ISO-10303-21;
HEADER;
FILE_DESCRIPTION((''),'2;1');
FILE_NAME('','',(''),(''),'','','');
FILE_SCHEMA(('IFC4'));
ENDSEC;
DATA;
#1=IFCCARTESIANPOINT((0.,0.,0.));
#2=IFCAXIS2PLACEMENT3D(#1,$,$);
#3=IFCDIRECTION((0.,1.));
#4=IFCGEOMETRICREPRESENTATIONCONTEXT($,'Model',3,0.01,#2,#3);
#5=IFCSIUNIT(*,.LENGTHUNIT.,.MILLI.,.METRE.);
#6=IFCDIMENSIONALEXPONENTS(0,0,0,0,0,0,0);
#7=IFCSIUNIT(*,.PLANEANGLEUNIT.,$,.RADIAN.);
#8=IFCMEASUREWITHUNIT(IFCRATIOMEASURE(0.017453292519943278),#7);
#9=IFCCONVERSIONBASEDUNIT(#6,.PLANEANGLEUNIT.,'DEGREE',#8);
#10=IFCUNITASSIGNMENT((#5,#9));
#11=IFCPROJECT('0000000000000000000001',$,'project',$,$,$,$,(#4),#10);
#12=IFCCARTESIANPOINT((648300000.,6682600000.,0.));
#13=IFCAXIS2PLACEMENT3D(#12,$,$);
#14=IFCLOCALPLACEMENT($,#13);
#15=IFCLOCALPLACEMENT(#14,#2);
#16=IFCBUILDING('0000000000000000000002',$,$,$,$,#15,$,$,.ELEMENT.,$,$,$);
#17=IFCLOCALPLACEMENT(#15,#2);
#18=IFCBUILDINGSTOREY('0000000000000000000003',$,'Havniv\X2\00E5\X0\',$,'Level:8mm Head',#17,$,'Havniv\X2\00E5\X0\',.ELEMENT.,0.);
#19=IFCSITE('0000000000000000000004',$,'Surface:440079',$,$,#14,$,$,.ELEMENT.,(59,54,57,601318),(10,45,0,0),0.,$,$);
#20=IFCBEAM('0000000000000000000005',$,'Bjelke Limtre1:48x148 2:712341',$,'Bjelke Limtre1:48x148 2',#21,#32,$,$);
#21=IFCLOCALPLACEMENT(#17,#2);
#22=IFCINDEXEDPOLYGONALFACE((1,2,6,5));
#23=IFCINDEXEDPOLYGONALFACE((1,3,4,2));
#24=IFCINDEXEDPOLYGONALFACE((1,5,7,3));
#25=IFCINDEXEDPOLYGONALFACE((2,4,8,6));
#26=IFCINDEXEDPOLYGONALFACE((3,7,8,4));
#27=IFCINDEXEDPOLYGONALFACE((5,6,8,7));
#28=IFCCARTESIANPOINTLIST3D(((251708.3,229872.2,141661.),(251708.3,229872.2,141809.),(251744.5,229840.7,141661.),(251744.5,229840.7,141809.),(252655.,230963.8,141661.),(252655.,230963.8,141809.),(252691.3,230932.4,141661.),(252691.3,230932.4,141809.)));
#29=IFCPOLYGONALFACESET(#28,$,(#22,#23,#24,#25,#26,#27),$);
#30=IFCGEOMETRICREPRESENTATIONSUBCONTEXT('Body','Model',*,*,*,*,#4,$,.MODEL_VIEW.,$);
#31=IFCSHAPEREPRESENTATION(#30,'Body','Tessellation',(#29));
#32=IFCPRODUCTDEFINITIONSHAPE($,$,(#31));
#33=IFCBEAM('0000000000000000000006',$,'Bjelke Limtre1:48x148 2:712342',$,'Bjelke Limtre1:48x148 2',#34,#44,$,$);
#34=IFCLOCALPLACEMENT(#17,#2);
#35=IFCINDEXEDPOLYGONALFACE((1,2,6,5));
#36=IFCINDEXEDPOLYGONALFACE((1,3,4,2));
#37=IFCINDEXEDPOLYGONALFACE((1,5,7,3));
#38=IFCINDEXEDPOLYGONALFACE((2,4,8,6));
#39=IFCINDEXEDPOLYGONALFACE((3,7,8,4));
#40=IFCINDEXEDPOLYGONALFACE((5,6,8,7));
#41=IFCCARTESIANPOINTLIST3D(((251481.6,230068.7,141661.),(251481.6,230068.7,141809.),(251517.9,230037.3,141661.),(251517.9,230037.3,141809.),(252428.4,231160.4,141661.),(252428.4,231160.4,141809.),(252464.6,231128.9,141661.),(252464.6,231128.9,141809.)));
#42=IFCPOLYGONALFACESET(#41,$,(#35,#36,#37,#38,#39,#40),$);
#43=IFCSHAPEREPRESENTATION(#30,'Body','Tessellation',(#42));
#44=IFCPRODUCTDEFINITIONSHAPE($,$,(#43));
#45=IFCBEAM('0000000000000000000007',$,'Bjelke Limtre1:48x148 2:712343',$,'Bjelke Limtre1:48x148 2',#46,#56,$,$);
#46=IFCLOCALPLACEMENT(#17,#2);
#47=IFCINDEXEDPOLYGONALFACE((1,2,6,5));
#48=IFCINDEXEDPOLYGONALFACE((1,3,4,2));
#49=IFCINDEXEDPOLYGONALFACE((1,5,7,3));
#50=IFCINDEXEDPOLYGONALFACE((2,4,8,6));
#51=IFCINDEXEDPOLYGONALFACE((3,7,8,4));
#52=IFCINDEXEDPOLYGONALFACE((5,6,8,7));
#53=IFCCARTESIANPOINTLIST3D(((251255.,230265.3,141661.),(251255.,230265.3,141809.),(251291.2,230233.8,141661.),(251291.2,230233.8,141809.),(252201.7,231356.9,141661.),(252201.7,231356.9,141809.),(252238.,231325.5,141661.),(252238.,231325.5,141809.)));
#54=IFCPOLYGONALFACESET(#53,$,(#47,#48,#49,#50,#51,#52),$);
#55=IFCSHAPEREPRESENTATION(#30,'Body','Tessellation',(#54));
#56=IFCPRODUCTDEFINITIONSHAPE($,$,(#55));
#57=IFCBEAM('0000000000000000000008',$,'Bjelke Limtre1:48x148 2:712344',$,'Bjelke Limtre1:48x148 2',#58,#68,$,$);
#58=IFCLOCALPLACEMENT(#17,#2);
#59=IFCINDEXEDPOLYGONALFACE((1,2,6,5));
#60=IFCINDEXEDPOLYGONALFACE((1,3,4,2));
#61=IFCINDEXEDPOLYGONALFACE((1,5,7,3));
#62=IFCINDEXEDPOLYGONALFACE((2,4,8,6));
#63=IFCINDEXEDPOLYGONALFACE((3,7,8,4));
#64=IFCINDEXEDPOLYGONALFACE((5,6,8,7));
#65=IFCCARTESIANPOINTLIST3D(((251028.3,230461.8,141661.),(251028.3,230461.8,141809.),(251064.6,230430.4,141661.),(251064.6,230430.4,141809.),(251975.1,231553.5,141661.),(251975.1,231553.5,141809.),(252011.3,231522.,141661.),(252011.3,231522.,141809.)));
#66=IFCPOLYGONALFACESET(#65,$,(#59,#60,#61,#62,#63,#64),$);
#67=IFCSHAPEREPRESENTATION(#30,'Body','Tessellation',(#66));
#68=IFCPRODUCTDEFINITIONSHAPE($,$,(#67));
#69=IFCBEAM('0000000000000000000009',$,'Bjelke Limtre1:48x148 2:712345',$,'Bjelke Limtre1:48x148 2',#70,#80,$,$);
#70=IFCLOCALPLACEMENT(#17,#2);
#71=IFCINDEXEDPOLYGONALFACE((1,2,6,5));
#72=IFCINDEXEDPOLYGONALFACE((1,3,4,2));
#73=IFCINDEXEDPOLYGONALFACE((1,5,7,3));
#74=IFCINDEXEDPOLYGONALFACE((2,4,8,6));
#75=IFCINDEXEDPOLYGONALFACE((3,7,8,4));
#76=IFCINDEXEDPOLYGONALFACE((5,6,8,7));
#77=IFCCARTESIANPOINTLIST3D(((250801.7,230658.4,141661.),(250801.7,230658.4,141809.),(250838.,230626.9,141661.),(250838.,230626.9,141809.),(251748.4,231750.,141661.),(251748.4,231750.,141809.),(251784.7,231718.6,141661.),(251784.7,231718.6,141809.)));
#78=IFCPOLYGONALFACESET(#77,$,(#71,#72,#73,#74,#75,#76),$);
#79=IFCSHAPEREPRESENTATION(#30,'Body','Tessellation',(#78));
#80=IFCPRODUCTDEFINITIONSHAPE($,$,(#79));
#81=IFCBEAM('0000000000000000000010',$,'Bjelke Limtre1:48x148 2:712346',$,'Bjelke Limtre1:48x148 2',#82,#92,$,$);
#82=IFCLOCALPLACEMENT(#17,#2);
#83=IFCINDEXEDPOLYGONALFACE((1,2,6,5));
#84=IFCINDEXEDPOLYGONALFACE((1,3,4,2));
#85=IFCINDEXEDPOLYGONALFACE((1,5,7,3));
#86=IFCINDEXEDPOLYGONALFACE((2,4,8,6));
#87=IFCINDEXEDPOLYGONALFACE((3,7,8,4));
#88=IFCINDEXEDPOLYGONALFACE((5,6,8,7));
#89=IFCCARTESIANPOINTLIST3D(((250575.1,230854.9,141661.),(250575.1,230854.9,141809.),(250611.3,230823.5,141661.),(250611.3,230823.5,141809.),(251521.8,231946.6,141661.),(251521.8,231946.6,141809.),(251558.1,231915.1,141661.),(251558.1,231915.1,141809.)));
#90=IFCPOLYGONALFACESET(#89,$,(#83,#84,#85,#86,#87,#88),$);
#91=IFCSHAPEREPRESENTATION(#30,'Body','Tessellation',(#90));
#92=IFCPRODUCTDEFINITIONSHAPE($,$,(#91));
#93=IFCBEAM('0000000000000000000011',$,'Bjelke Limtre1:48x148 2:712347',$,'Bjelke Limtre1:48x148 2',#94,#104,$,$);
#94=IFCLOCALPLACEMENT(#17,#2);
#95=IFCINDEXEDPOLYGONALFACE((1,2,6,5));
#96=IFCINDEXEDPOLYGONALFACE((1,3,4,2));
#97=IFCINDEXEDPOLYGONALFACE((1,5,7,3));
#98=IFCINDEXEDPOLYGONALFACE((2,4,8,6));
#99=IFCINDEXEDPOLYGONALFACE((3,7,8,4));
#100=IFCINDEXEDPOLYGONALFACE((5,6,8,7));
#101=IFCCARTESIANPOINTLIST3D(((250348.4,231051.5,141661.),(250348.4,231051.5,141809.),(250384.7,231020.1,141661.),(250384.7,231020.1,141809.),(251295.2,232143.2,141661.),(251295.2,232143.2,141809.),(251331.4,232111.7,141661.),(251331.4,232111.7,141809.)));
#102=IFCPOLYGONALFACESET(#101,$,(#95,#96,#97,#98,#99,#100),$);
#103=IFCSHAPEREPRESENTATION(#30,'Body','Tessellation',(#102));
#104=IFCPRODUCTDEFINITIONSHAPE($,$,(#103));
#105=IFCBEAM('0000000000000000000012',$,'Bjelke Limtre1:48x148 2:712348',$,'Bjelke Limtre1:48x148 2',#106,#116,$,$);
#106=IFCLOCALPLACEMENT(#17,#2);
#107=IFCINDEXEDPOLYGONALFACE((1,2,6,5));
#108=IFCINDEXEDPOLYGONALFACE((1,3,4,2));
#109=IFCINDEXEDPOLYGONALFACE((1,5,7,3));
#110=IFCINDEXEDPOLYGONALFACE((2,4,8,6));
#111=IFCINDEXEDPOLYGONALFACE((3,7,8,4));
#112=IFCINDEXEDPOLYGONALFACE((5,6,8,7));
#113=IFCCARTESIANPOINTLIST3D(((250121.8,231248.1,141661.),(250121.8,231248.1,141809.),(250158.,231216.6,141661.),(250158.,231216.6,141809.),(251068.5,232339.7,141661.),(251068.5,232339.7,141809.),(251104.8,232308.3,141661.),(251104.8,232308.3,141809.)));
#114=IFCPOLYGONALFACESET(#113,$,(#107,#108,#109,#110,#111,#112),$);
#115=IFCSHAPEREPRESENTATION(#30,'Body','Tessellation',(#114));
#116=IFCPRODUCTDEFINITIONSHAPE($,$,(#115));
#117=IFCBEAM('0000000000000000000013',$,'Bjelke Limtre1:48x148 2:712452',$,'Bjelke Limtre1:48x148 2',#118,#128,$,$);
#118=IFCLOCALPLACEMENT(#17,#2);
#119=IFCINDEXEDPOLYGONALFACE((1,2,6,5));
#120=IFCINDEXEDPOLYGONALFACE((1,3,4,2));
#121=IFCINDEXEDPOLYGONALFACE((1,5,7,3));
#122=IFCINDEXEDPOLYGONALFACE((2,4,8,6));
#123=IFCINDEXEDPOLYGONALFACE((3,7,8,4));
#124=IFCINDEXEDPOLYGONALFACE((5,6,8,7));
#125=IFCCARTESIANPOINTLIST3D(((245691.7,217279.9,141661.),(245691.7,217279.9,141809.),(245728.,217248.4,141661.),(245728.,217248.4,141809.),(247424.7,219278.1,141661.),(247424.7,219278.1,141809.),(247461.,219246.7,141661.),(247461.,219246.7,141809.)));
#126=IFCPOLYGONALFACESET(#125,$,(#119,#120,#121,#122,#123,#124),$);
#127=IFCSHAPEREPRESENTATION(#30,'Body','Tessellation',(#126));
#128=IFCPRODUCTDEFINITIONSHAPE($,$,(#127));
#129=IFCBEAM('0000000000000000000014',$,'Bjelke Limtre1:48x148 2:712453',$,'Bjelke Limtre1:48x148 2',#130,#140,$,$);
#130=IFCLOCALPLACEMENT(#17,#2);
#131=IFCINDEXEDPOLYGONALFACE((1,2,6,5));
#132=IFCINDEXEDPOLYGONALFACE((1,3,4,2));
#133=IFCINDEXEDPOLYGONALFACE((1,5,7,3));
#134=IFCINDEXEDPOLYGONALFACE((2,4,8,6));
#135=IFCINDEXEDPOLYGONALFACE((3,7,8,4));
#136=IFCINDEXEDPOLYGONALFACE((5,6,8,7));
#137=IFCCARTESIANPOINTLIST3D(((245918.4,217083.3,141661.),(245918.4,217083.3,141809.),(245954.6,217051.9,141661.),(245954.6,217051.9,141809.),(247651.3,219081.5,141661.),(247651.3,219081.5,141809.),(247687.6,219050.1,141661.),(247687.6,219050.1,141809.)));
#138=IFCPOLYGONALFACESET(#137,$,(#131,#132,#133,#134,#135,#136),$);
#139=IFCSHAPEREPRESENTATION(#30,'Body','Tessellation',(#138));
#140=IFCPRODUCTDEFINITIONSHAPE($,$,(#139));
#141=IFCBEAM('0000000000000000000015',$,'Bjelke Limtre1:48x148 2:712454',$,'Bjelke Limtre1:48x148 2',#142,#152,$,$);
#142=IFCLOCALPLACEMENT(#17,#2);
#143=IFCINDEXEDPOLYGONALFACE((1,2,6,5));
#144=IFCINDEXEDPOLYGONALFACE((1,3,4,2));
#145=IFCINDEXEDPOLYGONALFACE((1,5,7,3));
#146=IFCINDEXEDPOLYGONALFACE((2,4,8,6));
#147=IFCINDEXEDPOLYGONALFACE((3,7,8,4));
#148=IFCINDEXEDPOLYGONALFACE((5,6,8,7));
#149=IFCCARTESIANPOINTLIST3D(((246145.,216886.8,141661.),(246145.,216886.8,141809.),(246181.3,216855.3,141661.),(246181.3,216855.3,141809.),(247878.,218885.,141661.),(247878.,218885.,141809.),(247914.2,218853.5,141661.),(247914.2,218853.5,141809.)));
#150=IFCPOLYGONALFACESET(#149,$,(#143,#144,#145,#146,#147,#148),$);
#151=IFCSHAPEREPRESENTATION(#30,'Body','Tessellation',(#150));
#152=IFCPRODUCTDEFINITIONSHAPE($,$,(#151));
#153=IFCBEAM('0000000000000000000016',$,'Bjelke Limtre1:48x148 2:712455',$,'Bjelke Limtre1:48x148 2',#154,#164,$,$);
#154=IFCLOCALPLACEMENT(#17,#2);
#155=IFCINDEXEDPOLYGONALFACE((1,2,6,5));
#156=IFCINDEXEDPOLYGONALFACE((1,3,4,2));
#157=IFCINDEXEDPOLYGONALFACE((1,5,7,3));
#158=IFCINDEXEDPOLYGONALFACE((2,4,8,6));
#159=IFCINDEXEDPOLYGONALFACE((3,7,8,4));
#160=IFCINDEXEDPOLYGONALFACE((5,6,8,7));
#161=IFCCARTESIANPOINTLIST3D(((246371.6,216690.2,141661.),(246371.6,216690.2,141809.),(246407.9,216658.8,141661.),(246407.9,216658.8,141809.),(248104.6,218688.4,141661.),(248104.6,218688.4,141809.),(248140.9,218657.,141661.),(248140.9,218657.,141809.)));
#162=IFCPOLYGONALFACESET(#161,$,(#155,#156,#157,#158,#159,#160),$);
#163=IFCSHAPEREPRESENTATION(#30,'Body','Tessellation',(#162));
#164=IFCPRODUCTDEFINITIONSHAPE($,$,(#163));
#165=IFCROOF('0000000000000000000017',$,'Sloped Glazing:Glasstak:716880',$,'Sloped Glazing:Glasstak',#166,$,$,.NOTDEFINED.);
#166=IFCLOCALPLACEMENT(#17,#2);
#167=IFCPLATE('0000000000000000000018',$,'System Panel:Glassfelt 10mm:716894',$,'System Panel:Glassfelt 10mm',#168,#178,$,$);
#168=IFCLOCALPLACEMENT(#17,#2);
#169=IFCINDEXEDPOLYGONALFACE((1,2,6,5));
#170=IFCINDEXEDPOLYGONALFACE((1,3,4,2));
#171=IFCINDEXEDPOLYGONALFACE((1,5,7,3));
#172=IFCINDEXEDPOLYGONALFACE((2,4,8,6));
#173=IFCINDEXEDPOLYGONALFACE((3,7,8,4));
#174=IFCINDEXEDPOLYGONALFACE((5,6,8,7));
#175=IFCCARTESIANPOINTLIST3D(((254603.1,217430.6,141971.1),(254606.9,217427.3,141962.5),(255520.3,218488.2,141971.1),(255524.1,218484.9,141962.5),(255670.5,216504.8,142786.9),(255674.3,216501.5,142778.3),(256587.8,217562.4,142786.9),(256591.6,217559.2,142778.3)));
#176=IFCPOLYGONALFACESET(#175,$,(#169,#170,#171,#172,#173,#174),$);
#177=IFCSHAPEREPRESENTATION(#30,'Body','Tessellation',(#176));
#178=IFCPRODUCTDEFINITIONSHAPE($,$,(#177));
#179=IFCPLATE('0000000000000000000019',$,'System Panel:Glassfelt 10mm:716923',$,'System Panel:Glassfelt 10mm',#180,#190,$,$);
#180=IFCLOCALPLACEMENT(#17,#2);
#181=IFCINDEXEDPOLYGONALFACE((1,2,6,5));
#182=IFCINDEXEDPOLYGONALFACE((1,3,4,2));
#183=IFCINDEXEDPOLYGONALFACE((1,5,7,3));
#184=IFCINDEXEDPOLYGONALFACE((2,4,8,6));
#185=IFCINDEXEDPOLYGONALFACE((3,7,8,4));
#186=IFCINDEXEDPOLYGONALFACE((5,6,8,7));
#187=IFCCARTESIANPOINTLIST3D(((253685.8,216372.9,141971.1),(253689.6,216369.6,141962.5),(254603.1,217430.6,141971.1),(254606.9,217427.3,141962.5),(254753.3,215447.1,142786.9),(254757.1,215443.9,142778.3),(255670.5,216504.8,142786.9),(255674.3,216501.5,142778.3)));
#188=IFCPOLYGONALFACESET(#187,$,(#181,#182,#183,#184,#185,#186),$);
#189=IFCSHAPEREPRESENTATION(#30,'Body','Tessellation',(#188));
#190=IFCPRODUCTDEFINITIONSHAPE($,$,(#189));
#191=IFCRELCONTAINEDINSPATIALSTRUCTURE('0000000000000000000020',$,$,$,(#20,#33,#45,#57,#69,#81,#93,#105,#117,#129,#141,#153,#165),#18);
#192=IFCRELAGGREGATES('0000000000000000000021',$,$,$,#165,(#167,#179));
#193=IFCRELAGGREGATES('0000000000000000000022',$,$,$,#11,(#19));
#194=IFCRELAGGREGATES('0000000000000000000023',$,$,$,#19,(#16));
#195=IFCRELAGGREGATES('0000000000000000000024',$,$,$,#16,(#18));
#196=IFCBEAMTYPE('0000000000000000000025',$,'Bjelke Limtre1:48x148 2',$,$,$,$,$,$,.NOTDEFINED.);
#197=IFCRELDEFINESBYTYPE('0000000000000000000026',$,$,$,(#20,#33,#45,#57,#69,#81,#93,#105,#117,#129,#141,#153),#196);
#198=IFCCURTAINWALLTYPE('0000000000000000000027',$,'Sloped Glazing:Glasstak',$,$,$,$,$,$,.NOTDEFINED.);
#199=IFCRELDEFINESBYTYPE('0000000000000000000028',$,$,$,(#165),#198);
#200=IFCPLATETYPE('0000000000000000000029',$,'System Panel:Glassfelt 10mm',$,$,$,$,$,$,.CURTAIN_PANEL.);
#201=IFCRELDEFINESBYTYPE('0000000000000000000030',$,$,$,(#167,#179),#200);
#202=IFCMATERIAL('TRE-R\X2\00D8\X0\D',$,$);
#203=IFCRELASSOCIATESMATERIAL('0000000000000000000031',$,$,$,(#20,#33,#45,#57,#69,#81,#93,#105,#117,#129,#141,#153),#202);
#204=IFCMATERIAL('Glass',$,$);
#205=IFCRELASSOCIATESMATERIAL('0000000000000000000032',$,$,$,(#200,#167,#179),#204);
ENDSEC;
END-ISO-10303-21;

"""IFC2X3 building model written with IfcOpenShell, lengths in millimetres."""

from ifc_helpers import new_model, entity, si_unit, converted_unit, direction, frame, frame_2d, origin, origin_2d_with_axis, place, context, subcontext, project, spatial, rectangle, extrude, source, transform, mapped, material, type_object, type_shapes, element, aggregate, save


model = new_model("IFC2X3")

# Units and contexts
model_context = context("Model", 3, precision=0.01, world=origin(), true_north=direction((0.0, 1.0)))
body_context = subcontext(model_context, "Body", "Model", "MODEL_VIEW")
ifc_project = project(units=[si_unit("LENGTHUNIT", "METRE", prefix="MILLI"), converted_unit("PLANEANGLEUNIT", "DEGREE", entity("IfcRatioMeasure", 0.017453292519943278), si_unit("PLANEANGLEUNIT", "RADIAN"), dimensions=[0, 0, 0, 0, 0, 0, 0])], contexts=[model_context])

# Site, building, storey
site_placement = place(None, frame((648300000.0, 6682600000.0, 0.0)))
site = spatial("IfcSite", under=ifc_project, at=site_placement, Name="Surface:440079", CompositionType="ELEMENT", RefLatitude=(59, 54, 57, 601318), RefLongitude=(10, 45, 0, 0), RefElevation=0.0)
building_placement = place(site_placement, origin())
building = spatial("IfcBuilding", under=site, at=building_placement, CompositionType="ELEMENT")
storey_placement = place(building_placement, origin())
storey = spatial("IfcBuildingStorey", under=building, at=storey_placement, Name="Havnivå", ObjectType="Level:8mm Head", LongName="Havnivå", CompositionType="ELEMENT", Elevation=0.0)

# Beams
ifc_material_1 = material(Name="TRE-RØD")
beam_type = type_object("IfcBeamType", Name="Bjelke Limtre1:48x148 2", PredefinedType="NOTDEFINED")
beam_1_placement = place(storey_placement, frame((252673.1, 230948.1, 141809.0), z_axis=(0.0, 0.0, 1.0), x_axis=(-0.655187, -0.755467, 0.0)))
element("IfcBeam", 1, at=beam_1_placement, inside=storey, type_object=beam_type, material=ifc_material_1, Name="Bjelke Limtre1:48x148 2:712341", ObjectType="Bjelke Limtre1:48x148 2", context=body_context, shape_type="SweptSolid", body=[
    extrude(rectangle(XDim=148.0, YDim=48.0, at=frame_2d((0.0, 0.0), x_axis=(1.0, 0.0))), frame((0.0, 0.0, -74.0), z_axis=(1.0, 0.0, 0.0), x_axis=(0.0, 0.0, -1.0)), (0.0, 0.0, 1.0), 1445.0),
])
beam_2_placement = place(storey_placement, frame((252446.5, 231144.6, 141809.0), z_axis=(0.0, 0.0, 1.0), x_axis=(-0.655187, -0.755467, 0.0)))
element("IfcBeam", 2, at=beam_2_placement, inside=storey, type_object=beam_type, material=ifc_material_1, Name="Bjelke Limtre1:48x148 2:712342", ObjectType="Bjelke Limtre1:48x148 2", context=body_context, shape_type="SweptSolid", body=[
    extrude(rectangle(XDim=148.0, YDim=48.0, at=frame_2d((0.0, 0.0), x_axis=(1.0, 0.0))), frame((0.0, 0.0, -74.0), z_axis=(1.0, 0.0, 0.0), x_axis=(0.0, 0.0, -1.0)), (0.0, 0.0, 1.0), 1445.0),
])
beam_3_placement = place(storey_placement, frame((252219.9, 231341.2, 141809.0), z_axis=(0.0, 0.0, 1.0), x_axis=(-0.655187, -0.755467, 0.0)))
element("IfcBeam", 3, at=beam_3_placement, inside=storey, type_object=beam_type, material=ifc_material_1, Name="Bjelke Limtre1:48x148 2:712343", ObjectType="Bjelke Limtre1:48x148 2", context=body_context, shape_type="SweptSolid", body=[
    extrude(rectangle(XDim=148.0, YDim=48.0, at=origin_2d_with_axis()), frame((0.0, 0.0, -74.0), z_axis=(1.0, 0.0, 0.0), x_axis=(0.0, 0.0, -1.0)), (0.0, 0.0, 1.0), 1445.0),
])
beam_4_placement = place(storey_placement, frame((251993.2, 231537.8, 141809.0), z_axis=(0.0, 0.0, 1.0), x_axis=(-0.655187, -0.755467, 0.0)))
element("IfcBeam", 4, at=beam_4_placement, inside=storey, type_object=beam_type, material=ifc_material_1, Name="Bjelke Limtre1:48x148 2:712344", ObjectType="Bjelke Limtre1:48x148 2", context=body_context, shape_type="SweptSolid", body=[
    extrude(rectangle(XDim=148.0, YDim=48.0, at=frame_2d((0.0, 0.0), x_axis=(1.0, 0.0))), frame((0.0, 0.0, -74.0), z_axis=(1.0, 0.0, 0.0), x_axis=(0.0, 0.0, -1.0)), (0.0, 0.0, 1.0), 1445.0),
])
for number, where, z_axis, x_axis, name in (
    (5, (251766.6, 231734.3, 141809.0), (0.0, 0.0, 1.0), (-0.655187, -0.755467, 0.0), "Bjelke Limtre1:48x148 2:712345"),
    (6, (251539.9, 231930.9, 141809.0), (0.0, 0.0, 1.0), (-0.655187, -0.755467, 0.0), "Bjelke Limtre1:48x148 2:712346"),
):
    element("IfcBeam", number, at=place(storey_placement, frame(where, z_axis=z_axis, x_axis=x_axis)), inside=storey, type_object=beam_type, material=ifc_material_1, Name=name, ObjectType="Bjelke Limtre1:48x148 2", context=body_context, shape_type="SweptSolid", body=[
        extrude(rectangle(XDim=148.0, YDim=48.0, at=origin_2d_with_axis()), frame((0.0, 0.0, -74.0), z_axis=(1.0, 0.0, 0.0), x_axis=(0.0, 0.0, -1.0)), (0.0, 0.0, 1.0), 1445.0),
    ])
for number, where, z_axis, x_axis, name in (
    (7, (251313.3, 232127.4, 141809.0), (0.0, 0.0, 1.0), (-0.655187, -0.755467, 0.0), "Bjelke Limtre1:48x148 2:712347"),
    (8, (251086.7, 232324.0, 141809.0), (0.0, 0.0, 1.0), (-0.655187, -0.755467, 0.0), "Bjelke Limtre1:48x148 2:712348"),
):
    element("IfcBeam", number, at=place(storey_placement, frame(where, z_axis=z_axis, x_axis=x_axis)), inside=storey, type_object=beam_type, material=ifc_material_1, Name=name, ObjectType="Bjelke Limtre1:48x148 2", context=body_context, shape_type="SweptSolid", body=[
        extrude(rectangle(XDim=148.0, YDim=48.0, at=frame_2d((0.0, 0.0), x_axis=(1.0, 0.0))), frame((0.0, 0.0, -74.0), z_axis=(1.0, 0.0, 0.0), x_axis=(0.0, 0.0, -1.0)), (0.0, 0.0, 1.0), 1445.0),
    ])
beam_5_placement = place(storey_placement, frame((247442.8, 219262.4, 141809.0), z_axis=(0.0, 0.0, 1.0), x_axis=(-0.655187, -0.755467, 0.0)))
element("IfcBeam", 9, at=beam_5_placement, inside=storey, type_object=beam_type, material=ifc_material_1, Name="Bjelke Limtre1:48x148 2:712452", ObjectType="Bjelke Limtre1:48x148 2", context=body_context, shape_type="SweptSolid", body=[
    extrude(rectangle(XDim=148.0, YDim=48.0, at=frame_2d((0.0, 0.0), x_axis=(1.0, 0.0))), frame((0.0, 0.0, -74.0), z_axis=(1.0, 0.0, 0.0), x_axis=(0.0, 0.0, -1.0)), (0.0, 0.0, 1.0), 2645.0),
])
beam_6_placement = place(storey_placement, frame((247669.5, 219065.8, 141809.0), z_axis=(0.0, 0.0, 1.0), x_axis=(-0.655187, -0.755467, 0.0)))
element("IfcBeam", 10, at=beam_6_placement, inside=storey, type_object=beam_type, material=ifc_material_1, Name="Bjelke Limtre1:48x148 2:712453", ObjectType="Bjelke Limtre1:48x148 2", context=body_context, shape_type="SweptSolid", body=[
    extrude(rectangle(XDim=148.0, YDim=48.0, at=origin_2d_with_axis()), frame((0.0, 0.0, -74.0), z_axis=(1.0, 0.0, 0.0), x_axis=(0.0, 0.0, -1.0)), (0.0, 0.0, 1.0), 2645.0),
])
beam_7_placement = place(storey_placement, frame((247896.1, 218869.3, 141809.0), z_axis=(0.0, 0.0, 1.0), x_axis=(-0.655187, -0.755467, 0.0)))
element("IfcBeam", 11, at=beam_7_placement, inside=storey, type_object=beam_type, material=ifc_material_1, Name="Bjelke Limtre1:48x148 2:712454", ObjectType="Bjelke Limtre1:48x148 2", context=body_context, shape_type="SweptSolid", body=[
    extrude(rectangle(XDim=148.0, YDim=48.0, at=frame_2d((0.0, 0.0), x_axis=(1.0, 0.0))), frame((0.0, 0.0, -74.0), z_axis=(1.0, 0.0, 0.0), x_axis=(0.0, 0.0, -1.0)), (0.0, 0.0, 1.0), 2645.0),
])
beam_8_placement = place(storey_placement, frame((248122.7, 218672.7, 141809.0), z_axis=(0.0, 0.0, 1.0), x_axis=(-0.655187, -0.755467, 0.0)))
element("IfcBeam", 12, at=beam_8_placement, inside=storey, type_object=beam_type, material=ifc_material_1, Name="Bjelke Limtre1:48x148 2:712455", ObjectType="Bjelke Limtre1:48x148 2", context=body_context, shape_type="SweptSolid", body=[
    extrude(rectangle(XDim=148.0, YDim=48.0, at=origin_2d_with_axis()), frame((0.0, 0.0, -74.0), z_axis=(1.0, 0.0, 0.0), x_axis=(0.0, 0.0, -1.0)), (0.0, 0.0, 1.0), 2645.0),
])

# Roof, plates
curtain_wall_type = type_object("IfcCurtainWallType", Name="Sloped Glazing:Glasstak", PredefinedType="NOTDEFINED")
roof_placement = place(storey_placement, origin())
roof = element("IfcRoof", 13, at=roof_placement, inside=storey, type_object=curtain_wall_type, Name="Sloped Glazing:Glasstak:716880", ObjectType="Sloped Glazing:Glasstak", ShapeType="NOTDEFINED")
ifc_material_2 = material(Name="Glass")
plate_type = type_object("IfcPlateType", Name="System Panel:Glassfelt 10mm", PredefinedType="CURTAIN_PANEL", material=ifc_material_2)
shared_shape_1 = source(origin(), body_context, "Body", "SweptSolid", [
    extrude(rectangle(XDim=10.0, YDim=1400.0, at=frame_2d((0.0, 0.0), x_axis=(1.0, 0.0))), frame((0.0, 10.0, 0.0), z_axis=(0.0, 0.0, 1.0), x_axis=(0.0, 1.0, 0.0)), (0.0, 0.0, 1.0), 1631.6),
])
type_shapes(plate_type, [shared_shape_1])
plate_1_placement = place(roof_placement, frame((255059.8, 217961.0, 141975.5), z_axis=(0.654253, -0.567409, 0.5), x_axis=(-0.655187, -0.755467, 0.0)))
plate_1 = element("IfcPlate", 14, at=plate_1_placement, type_object=plate_type, material=ifc_material_2, Name="System Panel:Glassfelt 10mm:716894", ObjectType="System Panel:Glassfelt 10mm", context=body_context, shape_type="MappedRepresentation", body=[
    mapped(shared_shape_1, transform((0.0, 0.0, 0.0), scale=1.0)),
])
plate_2_placement = place(roof_placement, frame((254142.6, 216903.4, 141975.5), z_axis=(0.654253, -0.567409, 0.5), x_axis=(-0.655187, -0.755467, 0.0)))
plate_2 = element("IfcPlate", 15, at=plate_2_placement, type_object=plate_type, material=ifc_material_2, Name="System Panel:Glassfelt 10mm:716923", ObjectType="System Panel:Glassfelt 10mm", context=body_context, shape_type="MappedRepresentation", body=[
    mapped(shared_shape_1, transform((0.0, 0.0, 0.0), scale=1.0)),
])
aggregate(roof, [plate_1, plate_2])

save(model, "model.ifc")
